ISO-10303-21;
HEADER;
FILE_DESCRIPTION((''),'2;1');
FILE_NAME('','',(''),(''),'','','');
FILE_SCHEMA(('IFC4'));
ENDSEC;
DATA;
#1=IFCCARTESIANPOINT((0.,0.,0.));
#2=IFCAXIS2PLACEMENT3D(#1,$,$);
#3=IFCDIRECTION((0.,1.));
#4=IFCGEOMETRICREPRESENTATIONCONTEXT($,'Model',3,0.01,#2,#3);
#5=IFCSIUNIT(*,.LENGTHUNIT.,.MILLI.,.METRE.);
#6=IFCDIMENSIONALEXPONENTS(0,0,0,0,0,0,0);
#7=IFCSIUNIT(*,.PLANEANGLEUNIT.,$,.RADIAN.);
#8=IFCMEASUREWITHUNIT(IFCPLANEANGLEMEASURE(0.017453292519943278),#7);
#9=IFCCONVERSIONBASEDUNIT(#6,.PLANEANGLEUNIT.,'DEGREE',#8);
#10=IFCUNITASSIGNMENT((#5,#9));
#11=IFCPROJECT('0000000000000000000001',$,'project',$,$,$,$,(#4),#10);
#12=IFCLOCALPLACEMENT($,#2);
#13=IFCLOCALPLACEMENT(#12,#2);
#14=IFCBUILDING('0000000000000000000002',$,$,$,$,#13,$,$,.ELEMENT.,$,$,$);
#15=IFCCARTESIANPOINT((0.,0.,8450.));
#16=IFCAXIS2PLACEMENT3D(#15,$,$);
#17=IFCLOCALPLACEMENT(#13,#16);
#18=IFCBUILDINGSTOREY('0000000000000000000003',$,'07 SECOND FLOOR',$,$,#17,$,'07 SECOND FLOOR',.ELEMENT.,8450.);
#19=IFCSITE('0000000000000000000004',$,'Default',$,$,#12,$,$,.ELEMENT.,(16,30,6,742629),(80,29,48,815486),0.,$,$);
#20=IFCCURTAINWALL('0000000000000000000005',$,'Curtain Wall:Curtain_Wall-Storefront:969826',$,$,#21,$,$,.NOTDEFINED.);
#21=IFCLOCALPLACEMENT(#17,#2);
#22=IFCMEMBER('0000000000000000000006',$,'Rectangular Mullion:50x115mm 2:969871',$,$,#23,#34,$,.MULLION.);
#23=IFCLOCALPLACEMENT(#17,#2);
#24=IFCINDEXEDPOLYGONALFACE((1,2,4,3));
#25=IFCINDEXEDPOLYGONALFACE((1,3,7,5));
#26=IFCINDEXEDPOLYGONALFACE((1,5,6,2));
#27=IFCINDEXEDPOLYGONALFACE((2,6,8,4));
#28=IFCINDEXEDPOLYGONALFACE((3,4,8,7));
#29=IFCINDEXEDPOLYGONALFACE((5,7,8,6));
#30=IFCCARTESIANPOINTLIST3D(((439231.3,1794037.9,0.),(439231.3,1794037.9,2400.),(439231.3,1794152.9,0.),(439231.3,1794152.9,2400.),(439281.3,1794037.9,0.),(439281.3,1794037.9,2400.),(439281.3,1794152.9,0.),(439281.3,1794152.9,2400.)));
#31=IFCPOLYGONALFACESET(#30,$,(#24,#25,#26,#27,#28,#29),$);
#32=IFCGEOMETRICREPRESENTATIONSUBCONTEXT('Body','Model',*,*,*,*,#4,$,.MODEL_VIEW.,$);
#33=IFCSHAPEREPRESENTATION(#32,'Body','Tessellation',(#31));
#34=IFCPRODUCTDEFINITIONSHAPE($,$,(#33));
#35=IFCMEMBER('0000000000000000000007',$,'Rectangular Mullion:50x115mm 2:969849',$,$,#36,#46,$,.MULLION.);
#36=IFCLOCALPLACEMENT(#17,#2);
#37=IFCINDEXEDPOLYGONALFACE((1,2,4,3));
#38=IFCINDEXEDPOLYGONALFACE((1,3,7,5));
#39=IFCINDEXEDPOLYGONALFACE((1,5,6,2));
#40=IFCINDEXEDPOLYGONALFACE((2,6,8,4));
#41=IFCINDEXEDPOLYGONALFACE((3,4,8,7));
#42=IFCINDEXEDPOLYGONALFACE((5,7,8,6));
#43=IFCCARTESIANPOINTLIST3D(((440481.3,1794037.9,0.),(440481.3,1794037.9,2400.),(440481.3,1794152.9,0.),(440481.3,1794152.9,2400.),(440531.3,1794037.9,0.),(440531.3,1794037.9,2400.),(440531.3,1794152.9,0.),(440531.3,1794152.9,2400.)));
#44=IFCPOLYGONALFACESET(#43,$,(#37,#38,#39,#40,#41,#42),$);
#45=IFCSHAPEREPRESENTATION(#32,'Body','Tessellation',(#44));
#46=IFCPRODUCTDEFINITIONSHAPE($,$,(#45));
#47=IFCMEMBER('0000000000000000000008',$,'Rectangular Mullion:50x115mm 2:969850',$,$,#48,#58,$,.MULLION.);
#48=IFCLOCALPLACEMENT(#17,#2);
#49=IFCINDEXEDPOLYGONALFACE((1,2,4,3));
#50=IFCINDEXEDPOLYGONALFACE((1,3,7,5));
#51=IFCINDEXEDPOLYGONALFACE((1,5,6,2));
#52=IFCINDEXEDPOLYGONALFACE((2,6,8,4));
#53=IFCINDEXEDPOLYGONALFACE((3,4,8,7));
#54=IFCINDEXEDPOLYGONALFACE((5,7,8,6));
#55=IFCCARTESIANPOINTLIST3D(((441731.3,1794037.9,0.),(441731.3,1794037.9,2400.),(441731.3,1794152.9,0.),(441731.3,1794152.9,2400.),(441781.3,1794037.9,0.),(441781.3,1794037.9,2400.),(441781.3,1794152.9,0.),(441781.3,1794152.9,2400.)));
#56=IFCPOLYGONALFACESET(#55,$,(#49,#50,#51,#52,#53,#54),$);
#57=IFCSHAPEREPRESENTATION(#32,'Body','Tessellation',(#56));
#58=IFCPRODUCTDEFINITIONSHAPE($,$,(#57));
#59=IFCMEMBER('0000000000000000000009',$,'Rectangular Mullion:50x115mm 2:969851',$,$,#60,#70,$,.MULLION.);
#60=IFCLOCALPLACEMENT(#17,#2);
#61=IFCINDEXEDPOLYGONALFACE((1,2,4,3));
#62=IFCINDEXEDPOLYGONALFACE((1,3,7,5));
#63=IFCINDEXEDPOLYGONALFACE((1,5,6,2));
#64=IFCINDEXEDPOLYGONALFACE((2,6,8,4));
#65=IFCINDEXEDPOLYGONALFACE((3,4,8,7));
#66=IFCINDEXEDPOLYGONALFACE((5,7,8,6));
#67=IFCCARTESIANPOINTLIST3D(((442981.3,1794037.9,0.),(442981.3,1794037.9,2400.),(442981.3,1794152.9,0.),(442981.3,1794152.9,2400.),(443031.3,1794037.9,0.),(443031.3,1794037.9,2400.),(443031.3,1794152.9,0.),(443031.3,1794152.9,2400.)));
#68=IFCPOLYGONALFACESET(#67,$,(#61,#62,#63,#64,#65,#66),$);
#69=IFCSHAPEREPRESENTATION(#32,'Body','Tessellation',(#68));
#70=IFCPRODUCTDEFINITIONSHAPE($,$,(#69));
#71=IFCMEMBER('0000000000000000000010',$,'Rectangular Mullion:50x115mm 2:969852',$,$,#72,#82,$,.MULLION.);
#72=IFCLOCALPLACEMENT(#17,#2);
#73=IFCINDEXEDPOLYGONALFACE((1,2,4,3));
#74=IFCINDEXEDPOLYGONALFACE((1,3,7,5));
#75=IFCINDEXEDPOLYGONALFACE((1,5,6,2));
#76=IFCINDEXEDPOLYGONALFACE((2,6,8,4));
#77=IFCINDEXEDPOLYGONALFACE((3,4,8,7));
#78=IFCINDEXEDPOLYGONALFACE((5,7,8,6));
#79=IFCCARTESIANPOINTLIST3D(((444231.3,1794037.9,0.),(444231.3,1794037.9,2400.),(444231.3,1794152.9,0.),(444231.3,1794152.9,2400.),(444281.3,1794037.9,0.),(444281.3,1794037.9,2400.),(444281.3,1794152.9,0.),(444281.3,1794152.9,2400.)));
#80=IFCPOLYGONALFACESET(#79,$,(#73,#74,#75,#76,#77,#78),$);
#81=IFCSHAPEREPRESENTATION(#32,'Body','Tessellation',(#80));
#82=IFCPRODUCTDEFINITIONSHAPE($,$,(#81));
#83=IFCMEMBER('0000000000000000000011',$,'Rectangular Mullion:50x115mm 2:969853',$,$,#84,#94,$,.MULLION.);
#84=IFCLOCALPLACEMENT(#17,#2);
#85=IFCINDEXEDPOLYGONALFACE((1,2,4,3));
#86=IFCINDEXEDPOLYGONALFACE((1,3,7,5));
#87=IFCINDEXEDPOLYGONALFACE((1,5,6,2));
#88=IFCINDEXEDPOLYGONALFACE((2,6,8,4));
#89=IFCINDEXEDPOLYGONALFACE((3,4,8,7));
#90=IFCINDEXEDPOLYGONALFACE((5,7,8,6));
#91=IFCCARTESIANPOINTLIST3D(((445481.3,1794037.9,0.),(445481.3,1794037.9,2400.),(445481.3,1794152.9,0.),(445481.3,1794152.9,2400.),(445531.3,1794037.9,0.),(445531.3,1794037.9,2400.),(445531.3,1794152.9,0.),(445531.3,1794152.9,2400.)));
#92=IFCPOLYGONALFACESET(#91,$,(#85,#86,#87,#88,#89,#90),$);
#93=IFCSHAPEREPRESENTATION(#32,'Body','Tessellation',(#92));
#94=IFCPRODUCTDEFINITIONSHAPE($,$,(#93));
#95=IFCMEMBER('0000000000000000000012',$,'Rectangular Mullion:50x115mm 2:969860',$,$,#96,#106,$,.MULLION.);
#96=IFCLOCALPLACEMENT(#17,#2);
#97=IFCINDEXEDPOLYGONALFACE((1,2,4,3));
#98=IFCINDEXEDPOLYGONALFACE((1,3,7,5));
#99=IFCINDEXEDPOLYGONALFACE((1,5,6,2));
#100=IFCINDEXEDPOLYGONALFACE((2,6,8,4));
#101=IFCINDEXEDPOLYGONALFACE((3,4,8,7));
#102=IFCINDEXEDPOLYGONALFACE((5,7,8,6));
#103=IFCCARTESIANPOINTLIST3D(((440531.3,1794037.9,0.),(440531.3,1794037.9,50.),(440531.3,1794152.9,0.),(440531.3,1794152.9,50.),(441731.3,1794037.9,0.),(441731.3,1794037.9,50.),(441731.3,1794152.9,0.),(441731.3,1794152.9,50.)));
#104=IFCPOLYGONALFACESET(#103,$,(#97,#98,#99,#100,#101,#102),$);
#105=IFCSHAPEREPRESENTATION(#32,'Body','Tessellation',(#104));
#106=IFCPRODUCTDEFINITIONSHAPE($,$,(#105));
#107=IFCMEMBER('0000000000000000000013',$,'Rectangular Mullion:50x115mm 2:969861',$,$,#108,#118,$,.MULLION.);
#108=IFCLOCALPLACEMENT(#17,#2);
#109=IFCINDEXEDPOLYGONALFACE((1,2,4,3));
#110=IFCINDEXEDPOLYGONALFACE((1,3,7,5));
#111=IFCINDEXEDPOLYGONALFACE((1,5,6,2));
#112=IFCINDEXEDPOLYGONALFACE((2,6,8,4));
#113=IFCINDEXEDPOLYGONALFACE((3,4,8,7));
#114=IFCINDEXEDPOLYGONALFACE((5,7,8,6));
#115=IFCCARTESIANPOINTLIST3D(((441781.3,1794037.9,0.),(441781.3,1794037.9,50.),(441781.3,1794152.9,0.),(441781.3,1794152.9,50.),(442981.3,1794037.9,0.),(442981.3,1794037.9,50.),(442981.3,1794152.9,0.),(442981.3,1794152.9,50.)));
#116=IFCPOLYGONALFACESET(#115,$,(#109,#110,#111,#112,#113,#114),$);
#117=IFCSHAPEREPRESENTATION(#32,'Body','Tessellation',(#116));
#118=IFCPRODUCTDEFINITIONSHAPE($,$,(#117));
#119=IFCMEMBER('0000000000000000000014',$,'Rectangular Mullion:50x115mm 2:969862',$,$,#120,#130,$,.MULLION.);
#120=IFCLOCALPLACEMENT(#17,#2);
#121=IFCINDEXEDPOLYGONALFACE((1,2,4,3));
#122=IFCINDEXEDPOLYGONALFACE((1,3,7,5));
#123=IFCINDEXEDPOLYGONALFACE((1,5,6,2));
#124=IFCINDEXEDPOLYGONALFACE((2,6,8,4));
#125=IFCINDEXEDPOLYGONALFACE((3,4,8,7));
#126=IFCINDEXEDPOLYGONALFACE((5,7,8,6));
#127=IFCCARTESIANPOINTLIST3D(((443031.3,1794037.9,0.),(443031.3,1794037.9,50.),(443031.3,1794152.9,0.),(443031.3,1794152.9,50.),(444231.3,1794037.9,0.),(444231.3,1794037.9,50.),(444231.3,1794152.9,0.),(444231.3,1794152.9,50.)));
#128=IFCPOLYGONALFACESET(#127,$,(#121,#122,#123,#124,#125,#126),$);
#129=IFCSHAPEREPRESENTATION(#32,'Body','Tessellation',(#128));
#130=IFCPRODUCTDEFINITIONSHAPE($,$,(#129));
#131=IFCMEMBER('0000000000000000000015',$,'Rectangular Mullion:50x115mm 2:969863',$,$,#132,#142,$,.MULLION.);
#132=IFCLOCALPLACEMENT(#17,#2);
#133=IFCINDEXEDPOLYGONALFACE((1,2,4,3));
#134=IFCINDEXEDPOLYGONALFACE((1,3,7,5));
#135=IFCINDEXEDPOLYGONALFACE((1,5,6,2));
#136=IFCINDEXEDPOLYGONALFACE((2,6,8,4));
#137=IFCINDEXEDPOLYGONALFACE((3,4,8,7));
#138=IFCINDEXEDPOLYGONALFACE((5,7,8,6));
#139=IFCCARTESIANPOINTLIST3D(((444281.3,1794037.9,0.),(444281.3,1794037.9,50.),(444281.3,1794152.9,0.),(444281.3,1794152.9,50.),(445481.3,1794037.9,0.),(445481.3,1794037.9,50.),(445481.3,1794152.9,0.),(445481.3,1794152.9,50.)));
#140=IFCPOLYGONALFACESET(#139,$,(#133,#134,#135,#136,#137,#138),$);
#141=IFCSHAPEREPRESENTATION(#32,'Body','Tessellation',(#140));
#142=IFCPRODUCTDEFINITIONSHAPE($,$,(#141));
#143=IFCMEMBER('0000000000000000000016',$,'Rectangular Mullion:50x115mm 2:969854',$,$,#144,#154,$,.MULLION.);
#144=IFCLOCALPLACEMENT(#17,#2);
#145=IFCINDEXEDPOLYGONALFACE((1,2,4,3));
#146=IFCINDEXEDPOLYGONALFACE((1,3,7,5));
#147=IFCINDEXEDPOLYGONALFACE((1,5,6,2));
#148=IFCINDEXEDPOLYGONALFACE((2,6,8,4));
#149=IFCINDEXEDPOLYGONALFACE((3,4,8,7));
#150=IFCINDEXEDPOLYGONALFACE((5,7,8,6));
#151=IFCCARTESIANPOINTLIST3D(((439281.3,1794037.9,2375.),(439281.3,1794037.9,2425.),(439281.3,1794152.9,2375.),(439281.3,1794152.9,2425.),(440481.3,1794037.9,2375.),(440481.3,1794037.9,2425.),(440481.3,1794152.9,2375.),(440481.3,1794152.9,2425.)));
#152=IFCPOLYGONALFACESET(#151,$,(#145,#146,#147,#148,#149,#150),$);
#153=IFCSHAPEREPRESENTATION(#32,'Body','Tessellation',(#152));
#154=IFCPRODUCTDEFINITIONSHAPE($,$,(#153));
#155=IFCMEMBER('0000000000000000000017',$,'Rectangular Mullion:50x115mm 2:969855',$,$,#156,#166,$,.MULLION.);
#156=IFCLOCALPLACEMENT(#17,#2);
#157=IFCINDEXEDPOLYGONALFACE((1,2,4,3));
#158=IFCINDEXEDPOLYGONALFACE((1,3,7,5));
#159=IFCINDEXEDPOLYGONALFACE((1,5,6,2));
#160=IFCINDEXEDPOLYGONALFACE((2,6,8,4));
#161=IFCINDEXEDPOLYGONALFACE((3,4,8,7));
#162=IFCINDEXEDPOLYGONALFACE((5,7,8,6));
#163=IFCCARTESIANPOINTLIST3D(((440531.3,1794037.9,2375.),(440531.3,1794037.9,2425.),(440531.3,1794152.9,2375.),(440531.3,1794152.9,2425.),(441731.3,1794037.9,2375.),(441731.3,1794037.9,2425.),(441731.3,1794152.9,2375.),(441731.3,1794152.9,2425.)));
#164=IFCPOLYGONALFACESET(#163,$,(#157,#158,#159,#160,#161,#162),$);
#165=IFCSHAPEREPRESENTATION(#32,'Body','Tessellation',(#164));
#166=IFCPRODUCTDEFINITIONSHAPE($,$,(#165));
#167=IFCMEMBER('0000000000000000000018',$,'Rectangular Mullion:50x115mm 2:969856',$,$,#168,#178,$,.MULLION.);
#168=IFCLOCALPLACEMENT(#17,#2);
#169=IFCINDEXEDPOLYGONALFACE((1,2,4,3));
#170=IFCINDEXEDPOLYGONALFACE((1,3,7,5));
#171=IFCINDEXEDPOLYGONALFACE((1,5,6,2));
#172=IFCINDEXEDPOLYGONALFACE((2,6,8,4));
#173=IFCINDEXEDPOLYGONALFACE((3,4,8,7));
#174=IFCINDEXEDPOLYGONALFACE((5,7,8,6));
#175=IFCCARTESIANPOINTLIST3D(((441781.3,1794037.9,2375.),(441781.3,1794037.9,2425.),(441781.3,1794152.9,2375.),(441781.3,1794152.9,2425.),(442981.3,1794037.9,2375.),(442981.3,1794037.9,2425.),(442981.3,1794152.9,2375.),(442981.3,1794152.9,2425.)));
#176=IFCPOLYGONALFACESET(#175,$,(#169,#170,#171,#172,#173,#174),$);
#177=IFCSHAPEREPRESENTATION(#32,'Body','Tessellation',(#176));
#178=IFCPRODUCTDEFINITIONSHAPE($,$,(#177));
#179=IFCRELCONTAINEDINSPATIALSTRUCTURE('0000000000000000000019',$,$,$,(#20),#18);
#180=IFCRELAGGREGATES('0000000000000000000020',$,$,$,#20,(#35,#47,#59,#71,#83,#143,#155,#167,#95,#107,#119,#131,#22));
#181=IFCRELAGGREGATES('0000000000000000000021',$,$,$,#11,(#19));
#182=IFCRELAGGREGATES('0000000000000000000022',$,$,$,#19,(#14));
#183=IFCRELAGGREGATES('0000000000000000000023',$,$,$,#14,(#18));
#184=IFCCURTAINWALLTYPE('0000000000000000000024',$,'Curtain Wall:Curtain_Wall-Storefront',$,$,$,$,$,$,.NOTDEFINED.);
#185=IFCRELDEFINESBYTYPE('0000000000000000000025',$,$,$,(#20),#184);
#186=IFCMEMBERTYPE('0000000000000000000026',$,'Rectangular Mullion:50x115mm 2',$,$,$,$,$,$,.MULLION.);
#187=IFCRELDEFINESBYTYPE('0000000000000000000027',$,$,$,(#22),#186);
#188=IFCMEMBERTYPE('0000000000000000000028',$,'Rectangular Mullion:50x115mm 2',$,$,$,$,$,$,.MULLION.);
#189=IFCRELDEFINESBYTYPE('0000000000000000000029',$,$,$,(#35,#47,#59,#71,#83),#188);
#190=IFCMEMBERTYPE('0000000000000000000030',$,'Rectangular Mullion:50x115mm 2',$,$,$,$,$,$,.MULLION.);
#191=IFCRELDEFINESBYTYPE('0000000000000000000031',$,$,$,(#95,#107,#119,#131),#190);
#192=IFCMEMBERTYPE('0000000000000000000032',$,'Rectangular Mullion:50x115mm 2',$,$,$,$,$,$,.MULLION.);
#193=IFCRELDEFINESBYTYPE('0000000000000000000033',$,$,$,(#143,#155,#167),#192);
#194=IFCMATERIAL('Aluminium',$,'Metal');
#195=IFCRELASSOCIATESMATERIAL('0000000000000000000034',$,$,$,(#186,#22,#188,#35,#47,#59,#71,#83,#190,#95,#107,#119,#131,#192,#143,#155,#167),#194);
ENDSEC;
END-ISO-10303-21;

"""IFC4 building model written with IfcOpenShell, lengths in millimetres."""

from ifc_helpers import new_model, entity, si_unit, converted_unit, direction, frame, origin, place, context, subcontext, project, spatial, indexed_curve, outline, extrude, source, transform, mapped, material, type_object, type_shapes, element, aggregate, save


model = new_model("IFC4")

# Units and contexts
model_context = context("Model", 3, precision=0.01, world=origin(), true_north=direction((0.0, 1.0)))
body_context = subcontext(model_context, "Body", "Model", "MODEL_VIEW")
ifc_project = project(units=[si_unit("LENGTHUNIT", "METRE", prefix="MILLI"), converted_unit("PLANEANGLEUNIT", "DEGREE", entity("IfcPlaneAngleMeasure", 0.017453292519943278), si_unit("PLANEANGLEUNIT", "RADIAN"), dimensions=[0, 0, 0, 0, 0, 0, 0])], contexts=[model_context])

# Site, building, storey
site_placement = place(None, origin())
site = spatial("IfcSite", under=ifc_project, at=site_placement, Name="Default", CompositionType="ELEMENT", RefLatitude=(16, 30, 6, 742629), RefLongitude=(80, 29, 48, 815486), RefElevation=0.0)
building_placement = place(site_placement, origin())
building = spatial("IfcBuilding", under=site, at=building_placement, CompositionType="ELEMENT")
storey_placement = place(building_placement, frame((0.0, 0.0, 8450.0)))
storey = spatial("IfcBuildingStorey", under=building, at=storey_placement, Name="07 SECOND FLOOR", LongName="07 SECOND FLOOR", CompositionType="ELEMENT", Elevation=8450.0)

# Curtain wall, members
curtain_wall_type = type_object("IfcCurtainWallType", Name="Curtain Wall:Curtain_Wall-Storefront", PredefinedType="NOTDEFINED")
curtain_wall_placement = place(storey_placement, frame((0.0, 0.0, -8450.0)))
curtain_wall = element("IfcCurtainWall", 1, at=curtain_wall_placement, inside=storey, type_object=curtain_wall_type, Name="Curtain Wall:Curtain_Wall-Storefront:969826", PredefinedType="NOTDEFINED")
ifc_material = material(Name="Aluminium", Category="Metal")
member_type_1 = type_object("IfcMemberType", Name="Rectangular Mullion:50x115mm 2", PredefinedType="MULLION", material=ifc_material)
shared_shape_1 = source(origin(), body_context, "Body", "SweptSolid", [
    extrude(outline(indexed_curve([(-25.0, -57.5), (25.0, -57.5), (25.0, 57.5), (-25.0, 57.5), (-25.0, -57.5)], self_intersect=False)), frame((-25.0, 0.0, -2400.0), z_axis=(0.0, 0.0, 1.0), x_axis=(-1.0, 0.0, 0.0)), (0.0, 0.0, 1.0), 2400.0),
])
type_shapes(member_type_1, [shared_shape_1])
member_1_placement = place(curtain_wall_placement, frame((439231.3, 1794095.4, 10850.0), z_axis=(0.0, 0.0, 1.0), x_axis=(-1.0, 0.0, 0.0)))
member_1 = element("IfcMember", 2, at=member_1_placement, type_object=member_type_1, material=ifc_material, Name="Rectangular Mullion:50x115mm 2:969871", PredefinedType="MULLION", context=body_context, shape_type="MappedRepresentation", body=[
    mapped(shared_shape_1, transform((0.0, 0.0, 0.0), scale=1.0)),
])
member_type_2 = type_object("IfcMemberType", Name="Rectangular Mullion:50x115mm 2", PredefinedType="MULLION", material=ifc_material)
shared_shape_2 = source(origin(), body_context, "Body", "SweptSolid", [
    extrude(outline(indexed_curve([(-25.0, -57.5), (25.0, -57.5), (25.0, 57.5), (-25.0, 57.5), (-25.0, -57.5)], self_intersect=False)), frame((0.0, 0.0, -2400.0), z_axis=(0.0, 0.0, 1.0), x_axis=(-1.0, 0.0, 0.0)), (0.0, 0.0, 1.0), 2400.0),
])
type_shapes(member_type_2, [shared_shape_2])
member_2_placement = place(curtain_wall_placement, frame((440506.3, 1794095.4, 8450.0), z_axis=(0.0, 0.0, -1.0), x_axis=(1.0, 0.0, 0.0)))
member_2 = element("IfcMember", 3, at=member_2_placement, type_object=member_type_2, material=ifc_material, Name="Rectangular Mullion:50x115mm 2:969849", PredefinedType="MULLION", context=body_context, shape_type="MappedRepresentation", body=[
    mapped(shared_shape_2, transform((0.0, 0.0, 0.0), scale=1.0)),
])
member_3_placement = place(curtain_wall_placement, frame((441756.3, 1794095.4, 8450.0), z_axis=(0.0, 0.0, -1.0), x_axis=(1.0, 0.0, 0.0)))
member_3 = element("IfcMember", 4, at=member_3_placement, type_object=member_type_2, material=ifc_material, Name="Rectangular Mullion:50x115mm 2:969850", PredefinedType="MULLION", context=body_context, shape_type="MappedRepresentation", body=[
    mapped(shared_shape_2, transform((0.0, 0.0, 0.0), scale=1.0)),
])
member_4_placement = place(curtain_wall_placement, frame((443006.3, 1794095.4, 8450.0), z_axis=(0.0, 0.0, -1.0), x_axis=(1.0, 0.0, 0.0)))
member_4 = element("IfcMember", 5, at=member_4_placement, type_object=member_type_2, material=ifc_material, Name="Rectangular Mullion:50x115mm 2:969851", PredefinedType="MULLION", context=body_context, shape_type="MappedRepresentation", body=[
    mapped(shared_shape_2, transform((0.0, 0.0, 0.0), scale=1.0)),
])
member_5_placement = place(curtain_wall_placement, frame((444256.3, 1794095.4, 8450.0), z_axis=(0.0, 0.0, -1.0), x_axis=(1.0, 0.0, 0.0)))
member_5 = element("IfcMember", 6, at=member_5_placement, type_object=member_type_2, material=ifc_material, Name="Rectangular Mullion:50x115mm 2:969852", PredefinedType="MULLION", context=body_context, shape_type="MappedRepresentation", body=[
    mapped(shared_shape_2, transform((0.0, 0.0, 0.0), scale=1.0)),
])
member_6_placement = place(curtain_wall_placement, frame((445506.3, 1794095.4, 8450.0), z_axis=(0.0, 0.0, -1.0), x_axis=(1.0, 0.0, 0.0)))
member_6 = element("IfcMember", 7, at=member_6_placement, type_object=member_type_2, material=ifc_material, Name="Rectangular Mullion:50x115mm 2:969853", PredefinedType="MULLION", context=body_context, shape_type="MappedRepresentation", body=[
    mapped(shared_shape_2, transform((0.0, 0.0, 0.0), scale=1.0)),
])
member_type_3 = type_object("IfcMemberType", Name="Rectangular Mullion:50x115mm 2", PredefinedType="MULLION", material=ifc_material)
shared_shape_3 = source(origin(), body_context, "Body", "SweptSolid", [
    extrude(outline(indexed_curve([(-25.0, -57.5), (25.0, -57.5), (25.0, 57.5), (-25.0, 57.5), (-25.0, -57.5)], self_intersect=False)), frame((-25.0, 0.0, -1200.0), z_axis=(0.0, 0.0, 1.0), x_axis=(-1.0, 0.0, 0.0)), (0.0, 0.0, 1.0), 1200.0),
])
type_shapes(member_type_3, [shared_shape_3])
member_7_placement = place(curtain_wall_placement, frame((440531.3, 1794095.4, 8450.0), z_axis=(-1.0, 0.0, 0.0), x_axis=(0.0, 0.0, -1.0)))
member_7 = element("IfcMember", 8, at=member_7_placement, type_object=member_type_3, material=ifc_material, Name="Rectangular Mullion:50x115mm 2:969860", PredefinedType="MULLION", context=body_context, shape_type="MappedRepresentation", body=[
    mapped(shared_shape_3, transform((0.0, 0.0, 0.0), scale=1.0)),
])
member_8_placement = place(curtain_wall_placement, frame((441781.3, 1794095.4, 8450.0), z_axis=(-1.0, 0.0, 0.0), x_axis=(0.0, 0.0, -1.0)))
member_8 = element("IfcMember", 9, at=member_8_placement, type_object=member_type_3, material=ifc_material, Name="Rectangular Mullion:50x115mm 2:969861", PredefinedType="MULLION", context=body_context, shape_type="MappedRepresentation", body=[
    mapped(shared_shape_3, transform((0.0, 0.0, 0.0), scale=1.0)),
])
member_9_placement = place(curtain_wall_placement, frame((443031.3, 1794095.4, 8450.0), z_axis=(-1.0, 0.0, 0.0), x_axis=(0.0, 0.0, -1.0)))
member_9 = element("IfcMember", 10, at=member_9_placement, type_object=member_type_3, material=ifc_material, Name="Rectangular Mullion:50x115mm 2:969862", PredefinedType="MULLION", context=body_context, shape_type="MappedRepresentation", body=[
    mapped(shared_shape_3, transform((0.0, 0.0, 0.0), scale=1.0)),
])
member_10_placement = place(curtain_wall_placement, frame((444281.3, 1794095.4, 8450.0), z_axis=(-1.0, 0.0, 0.0), x_axis=(0.0, 0.0, -1.0)))
member_10 = element("IfcMember", 11, at=member_10_placement, type_object=member_type_3, material=ifc_material, Name="Rectangular Mullion:50x115mm 2:969863", PredefinedType="MULLION", context=body_context, shape_type="MappedRepresentation", body=[
    mapped(shared_shape_3, transform((0.0, 0.0, 0.0), scale=1.0)),
])
member_type_4 = type_object("IfcMemberType", Name="Rectangular Mullion:50x115mm 2", PredefinedType="MULLION", material=ifc_material)
shared_shape_4 = source(origin(), body_context, "Body", "SweptSolid", [
    extrude(outline(indexed_curve([(-25.0, -57.5), (25.0, -57.5), (25.0, 57.5), (-25.0, 57.5), (-25.0, -57.5)], self_intersect=False)), frame((0.0, 0.0, -1200.0), z_axis=(0.0, 0.0, 1.0), x_axis=(-1.0, 0.0, 0.0)), (0.0, 0.0, 1.0), 1200.0),
])
type_shapes(member_type_4, [shared_shape_4])
member_11_placement = place(curtain_wall_placement, frame((440481.3, 1794095.4, 10850.0), z_axis=(1.0, 0.0, 0.0), x_axis=(0.0, 0.0, 1.0)))
member_11 = element("IfcMember", 12, at=member_11_placement, type_object=member_type_4, material=ifc_material, Name="Rectangular Mullion:50x115mm 2:969854", PredefinedType="MULLION", context=body_context, shape_type="MappedRepresentation", body=[
    mapped(shared_shape_4, transform((0.0, 0.0, 0.0), scale=1.0)),
])
member_12_placement = place(curtain_wall_placement, frame((441731.3, 1794095.4, 10850.0), z_axis=(1.0, 0.0, 0.0), x_axis=(0.0, 0.0, 1.0)))
member_12 = element("IfcMember", 13, at=member_12_placement, type_object=member_type_4, material=ifc_material, Name="Rectangular Mullion:50x115mm 2:969855", PredefinedType="MULLION", context=body_context, shape_type="MappedRepresentation", body=[
    mapped(shared_shape_4, transform((0.0, 0.0, 0.0), scale=1.0)),
])
member_13_placement = place(curtain_wall_placement, frame((442981.3, 1794095.4, 10850.0), z_axis=(1.0, 0.0, 0.0), x_axis=(0.0, 0.0, 1.0)))
member_13 = element("IfcMember", 14, at=member_13_placement, type_object=member_type_4, material=ifc_material, Name="Rectangular Mullion:50x115mm 2:969856", PredefinedType="MULLION", context=body_context, shape_type="MappedRepresentation", body=[
    mapped(shared_shape_4, transform((0.0, 0.0, 0.0), scale=1.0)),
])
aggregate(curtain_wall, [member_2, member_3, member_4, member_5, member_6, member_11, member_12, member_13, member_7, member_8, member_9, member_10, member_1])

save(model, "model.ifc")
